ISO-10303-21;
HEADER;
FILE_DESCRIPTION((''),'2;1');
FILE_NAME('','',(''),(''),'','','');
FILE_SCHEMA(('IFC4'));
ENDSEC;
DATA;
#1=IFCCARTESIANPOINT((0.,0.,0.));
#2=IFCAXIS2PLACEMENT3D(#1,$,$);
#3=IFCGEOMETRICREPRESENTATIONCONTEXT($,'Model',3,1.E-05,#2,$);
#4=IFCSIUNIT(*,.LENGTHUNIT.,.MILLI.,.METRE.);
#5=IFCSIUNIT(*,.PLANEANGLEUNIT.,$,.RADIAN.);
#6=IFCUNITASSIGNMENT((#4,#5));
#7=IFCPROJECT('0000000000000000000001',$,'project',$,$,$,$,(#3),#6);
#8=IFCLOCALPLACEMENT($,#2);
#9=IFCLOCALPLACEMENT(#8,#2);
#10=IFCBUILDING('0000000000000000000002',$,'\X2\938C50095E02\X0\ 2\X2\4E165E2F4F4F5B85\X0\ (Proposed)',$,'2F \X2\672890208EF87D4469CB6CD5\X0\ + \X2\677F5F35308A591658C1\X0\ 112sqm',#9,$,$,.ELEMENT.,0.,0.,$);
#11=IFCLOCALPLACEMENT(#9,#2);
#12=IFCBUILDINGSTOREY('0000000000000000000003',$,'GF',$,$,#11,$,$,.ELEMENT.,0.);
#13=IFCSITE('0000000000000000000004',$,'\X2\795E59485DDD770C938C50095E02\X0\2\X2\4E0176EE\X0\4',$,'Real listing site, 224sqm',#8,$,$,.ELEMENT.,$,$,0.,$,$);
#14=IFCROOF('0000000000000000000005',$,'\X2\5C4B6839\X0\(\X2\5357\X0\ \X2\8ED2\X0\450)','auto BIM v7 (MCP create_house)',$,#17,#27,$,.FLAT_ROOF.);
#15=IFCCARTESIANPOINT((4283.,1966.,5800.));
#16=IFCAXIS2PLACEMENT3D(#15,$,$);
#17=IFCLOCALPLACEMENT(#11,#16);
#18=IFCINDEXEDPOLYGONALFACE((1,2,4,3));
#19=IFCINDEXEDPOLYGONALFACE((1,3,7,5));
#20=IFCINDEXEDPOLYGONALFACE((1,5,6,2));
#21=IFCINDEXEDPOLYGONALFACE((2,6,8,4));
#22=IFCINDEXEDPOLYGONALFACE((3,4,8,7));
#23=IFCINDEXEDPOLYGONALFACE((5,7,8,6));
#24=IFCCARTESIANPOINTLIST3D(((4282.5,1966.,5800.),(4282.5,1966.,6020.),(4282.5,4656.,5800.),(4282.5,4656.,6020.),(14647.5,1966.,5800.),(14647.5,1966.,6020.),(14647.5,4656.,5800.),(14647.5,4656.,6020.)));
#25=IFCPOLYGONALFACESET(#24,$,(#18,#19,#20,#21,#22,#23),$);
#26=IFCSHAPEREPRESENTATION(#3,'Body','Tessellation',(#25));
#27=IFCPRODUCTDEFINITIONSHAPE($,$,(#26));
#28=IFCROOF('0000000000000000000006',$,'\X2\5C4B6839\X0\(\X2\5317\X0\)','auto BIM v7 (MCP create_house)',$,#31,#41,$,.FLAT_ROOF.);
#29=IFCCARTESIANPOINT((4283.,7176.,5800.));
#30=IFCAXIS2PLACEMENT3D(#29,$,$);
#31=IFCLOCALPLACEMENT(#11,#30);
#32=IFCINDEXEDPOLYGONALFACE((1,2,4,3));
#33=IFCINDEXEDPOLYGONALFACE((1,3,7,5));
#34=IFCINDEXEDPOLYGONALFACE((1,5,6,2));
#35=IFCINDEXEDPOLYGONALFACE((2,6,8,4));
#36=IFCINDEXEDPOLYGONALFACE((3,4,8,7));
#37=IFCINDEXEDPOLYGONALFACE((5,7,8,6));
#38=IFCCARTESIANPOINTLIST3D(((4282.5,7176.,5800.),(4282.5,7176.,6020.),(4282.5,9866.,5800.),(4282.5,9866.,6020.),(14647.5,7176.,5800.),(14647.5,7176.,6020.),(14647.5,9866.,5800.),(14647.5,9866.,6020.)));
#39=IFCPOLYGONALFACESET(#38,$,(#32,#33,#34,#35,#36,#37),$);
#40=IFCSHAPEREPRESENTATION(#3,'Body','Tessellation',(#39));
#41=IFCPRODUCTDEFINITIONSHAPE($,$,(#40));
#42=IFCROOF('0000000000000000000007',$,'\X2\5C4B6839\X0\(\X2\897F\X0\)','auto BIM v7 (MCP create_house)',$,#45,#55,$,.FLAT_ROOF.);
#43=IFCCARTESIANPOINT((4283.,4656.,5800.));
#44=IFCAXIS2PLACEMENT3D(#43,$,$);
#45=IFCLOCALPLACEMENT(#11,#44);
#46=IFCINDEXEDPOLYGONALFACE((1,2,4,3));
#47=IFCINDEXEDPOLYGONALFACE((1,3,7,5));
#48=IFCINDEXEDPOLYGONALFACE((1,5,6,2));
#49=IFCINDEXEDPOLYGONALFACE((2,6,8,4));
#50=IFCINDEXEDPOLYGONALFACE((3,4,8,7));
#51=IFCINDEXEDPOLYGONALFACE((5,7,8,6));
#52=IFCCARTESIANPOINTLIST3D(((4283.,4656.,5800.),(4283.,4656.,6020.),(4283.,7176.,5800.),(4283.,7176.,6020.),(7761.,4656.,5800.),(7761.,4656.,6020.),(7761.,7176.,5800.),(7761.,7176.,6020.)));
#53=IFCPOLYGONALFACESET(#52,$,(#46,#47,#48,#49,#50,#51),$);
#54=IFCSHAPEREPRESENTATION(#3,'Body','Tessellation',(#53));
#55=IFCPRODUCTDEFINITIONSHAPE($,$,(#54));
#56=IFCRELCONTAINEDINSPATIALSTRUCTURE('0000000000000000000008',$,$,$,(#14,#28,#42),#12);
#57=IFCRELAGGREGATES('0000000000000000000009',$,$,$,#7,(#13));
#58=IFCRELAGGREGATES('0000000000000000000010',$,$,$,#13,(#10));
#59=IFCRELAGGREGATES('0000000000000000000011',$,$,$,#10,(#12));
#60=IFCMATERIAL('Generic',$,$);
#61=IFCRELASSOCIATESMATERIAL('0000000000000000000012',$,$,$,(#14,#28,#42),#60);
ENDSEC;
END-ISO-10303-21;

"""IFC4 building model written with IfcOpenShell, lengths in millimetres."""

from ifc_helpers import new_model, si_unit, frame, frame_2d, origin, place, context, project, spatial, rectangle, extrude, material, element, save


model = new_model("IFC4")

# Units and contexts
model_context = context("Model", 3, precision=1e-05, world=origin())
ifc_project = project(units=[si_unit("LENGTHUNIT", "METRE", prefix="MILLI"), si_unit("PLANEANGLEUNIT", "RADIAN")], contexts=[model_context])

# Site, building, storey
site_placement = place(None, origin())
site = spatial("IfcSite", under=ifc_project, at=site_placement, Name="神奈川県鎌倉市2丁目4", ObjectType="Real listing site, 224sqm", CompositionType="ELEMENT", RefElevation=0.0)
building_placement = place(site_placement, origin())
building = spatial("IfcBuilding", under=site, at=building_placement, Name="鎌倉市 2世帯住宅 (Proposed)", ObjectType="2F 木造軸組構法 + 板張り外壁 112sqm", CompositionType="ELEMENT", ElevationOfRefHeight=0.0, ElevationOfTerrain=0.0)
storey_placement = place(building_placement, origin())
storey = spatial("IfcBuildingStorey", under=building, at=storey_placement, Name="GF", CompositionType="ELEMENT", Elevation=0.0)

# Shared definitions
ifc_material = material(Name="Generic")

# Roofs
roof_1_placement = place(storey_placement, frame((4283.0, 1966.0, 5800.0)))
element("IfcRoof", 1, at=roof_1_placement, inside=storey, material=ifc_material, Name="屋根(南 軒450)", Description="auto BIM v7 (MCP create_house)", PredefinedType="FLAT_ROOF", context=model_context, shape_type="SweptSolid", body=[
    extrude(rectangle(XDim=10365.0, YDim=2690.0, at=frame_2d((5182.0, 1345.0))), frame((4283.0, 1966.0, 5800.0)), (0.0, 0.0, 1.0), 220.0),
])
roof_2_placement = place(storey_placement, frame((4283.0, 7176.0, 5800.0)))
element("IfcRoof", 2, at=roof_2_placement, inside=storey, material=ifc_material, Name="屋根(北)", Description="auto BIM v7 (MCP create_house)", PredefinedType="FLAT_ROOF", context=model_context, shape_type="SweptSolid", body=[
    extrude(rectangle(XDim=10365.0, YDim=2690.0, at=frame_2d((5182.0, 1345.0))), frame((4283.0, 7176.0, 5800.0)), (0.0, 0.0, 1.0), 220.0),
])
roof_3_placement = place(storey_placement, frame((4283.0, 4656.0, 5800.0)))
element("IfcRoof", 3, at=roof_3_placement, inside=storey, material=ifc_material, Name="屋根(西)", Description="auto BIM v7 (MCP create_house)", PredefinedType="FLAT_ROOF", context=model_context, shape_type="SweptSolid", body=[
    extrude(rectangle(XDim=3478.0, YDim=2520.0, at=frame_2d((1739.0, 1260.0))), frame((4283.0, 4656.0, 5800.0)), (0.0, 0.0, 1.0), 220.0),
])

save(model, "model.ifc")
